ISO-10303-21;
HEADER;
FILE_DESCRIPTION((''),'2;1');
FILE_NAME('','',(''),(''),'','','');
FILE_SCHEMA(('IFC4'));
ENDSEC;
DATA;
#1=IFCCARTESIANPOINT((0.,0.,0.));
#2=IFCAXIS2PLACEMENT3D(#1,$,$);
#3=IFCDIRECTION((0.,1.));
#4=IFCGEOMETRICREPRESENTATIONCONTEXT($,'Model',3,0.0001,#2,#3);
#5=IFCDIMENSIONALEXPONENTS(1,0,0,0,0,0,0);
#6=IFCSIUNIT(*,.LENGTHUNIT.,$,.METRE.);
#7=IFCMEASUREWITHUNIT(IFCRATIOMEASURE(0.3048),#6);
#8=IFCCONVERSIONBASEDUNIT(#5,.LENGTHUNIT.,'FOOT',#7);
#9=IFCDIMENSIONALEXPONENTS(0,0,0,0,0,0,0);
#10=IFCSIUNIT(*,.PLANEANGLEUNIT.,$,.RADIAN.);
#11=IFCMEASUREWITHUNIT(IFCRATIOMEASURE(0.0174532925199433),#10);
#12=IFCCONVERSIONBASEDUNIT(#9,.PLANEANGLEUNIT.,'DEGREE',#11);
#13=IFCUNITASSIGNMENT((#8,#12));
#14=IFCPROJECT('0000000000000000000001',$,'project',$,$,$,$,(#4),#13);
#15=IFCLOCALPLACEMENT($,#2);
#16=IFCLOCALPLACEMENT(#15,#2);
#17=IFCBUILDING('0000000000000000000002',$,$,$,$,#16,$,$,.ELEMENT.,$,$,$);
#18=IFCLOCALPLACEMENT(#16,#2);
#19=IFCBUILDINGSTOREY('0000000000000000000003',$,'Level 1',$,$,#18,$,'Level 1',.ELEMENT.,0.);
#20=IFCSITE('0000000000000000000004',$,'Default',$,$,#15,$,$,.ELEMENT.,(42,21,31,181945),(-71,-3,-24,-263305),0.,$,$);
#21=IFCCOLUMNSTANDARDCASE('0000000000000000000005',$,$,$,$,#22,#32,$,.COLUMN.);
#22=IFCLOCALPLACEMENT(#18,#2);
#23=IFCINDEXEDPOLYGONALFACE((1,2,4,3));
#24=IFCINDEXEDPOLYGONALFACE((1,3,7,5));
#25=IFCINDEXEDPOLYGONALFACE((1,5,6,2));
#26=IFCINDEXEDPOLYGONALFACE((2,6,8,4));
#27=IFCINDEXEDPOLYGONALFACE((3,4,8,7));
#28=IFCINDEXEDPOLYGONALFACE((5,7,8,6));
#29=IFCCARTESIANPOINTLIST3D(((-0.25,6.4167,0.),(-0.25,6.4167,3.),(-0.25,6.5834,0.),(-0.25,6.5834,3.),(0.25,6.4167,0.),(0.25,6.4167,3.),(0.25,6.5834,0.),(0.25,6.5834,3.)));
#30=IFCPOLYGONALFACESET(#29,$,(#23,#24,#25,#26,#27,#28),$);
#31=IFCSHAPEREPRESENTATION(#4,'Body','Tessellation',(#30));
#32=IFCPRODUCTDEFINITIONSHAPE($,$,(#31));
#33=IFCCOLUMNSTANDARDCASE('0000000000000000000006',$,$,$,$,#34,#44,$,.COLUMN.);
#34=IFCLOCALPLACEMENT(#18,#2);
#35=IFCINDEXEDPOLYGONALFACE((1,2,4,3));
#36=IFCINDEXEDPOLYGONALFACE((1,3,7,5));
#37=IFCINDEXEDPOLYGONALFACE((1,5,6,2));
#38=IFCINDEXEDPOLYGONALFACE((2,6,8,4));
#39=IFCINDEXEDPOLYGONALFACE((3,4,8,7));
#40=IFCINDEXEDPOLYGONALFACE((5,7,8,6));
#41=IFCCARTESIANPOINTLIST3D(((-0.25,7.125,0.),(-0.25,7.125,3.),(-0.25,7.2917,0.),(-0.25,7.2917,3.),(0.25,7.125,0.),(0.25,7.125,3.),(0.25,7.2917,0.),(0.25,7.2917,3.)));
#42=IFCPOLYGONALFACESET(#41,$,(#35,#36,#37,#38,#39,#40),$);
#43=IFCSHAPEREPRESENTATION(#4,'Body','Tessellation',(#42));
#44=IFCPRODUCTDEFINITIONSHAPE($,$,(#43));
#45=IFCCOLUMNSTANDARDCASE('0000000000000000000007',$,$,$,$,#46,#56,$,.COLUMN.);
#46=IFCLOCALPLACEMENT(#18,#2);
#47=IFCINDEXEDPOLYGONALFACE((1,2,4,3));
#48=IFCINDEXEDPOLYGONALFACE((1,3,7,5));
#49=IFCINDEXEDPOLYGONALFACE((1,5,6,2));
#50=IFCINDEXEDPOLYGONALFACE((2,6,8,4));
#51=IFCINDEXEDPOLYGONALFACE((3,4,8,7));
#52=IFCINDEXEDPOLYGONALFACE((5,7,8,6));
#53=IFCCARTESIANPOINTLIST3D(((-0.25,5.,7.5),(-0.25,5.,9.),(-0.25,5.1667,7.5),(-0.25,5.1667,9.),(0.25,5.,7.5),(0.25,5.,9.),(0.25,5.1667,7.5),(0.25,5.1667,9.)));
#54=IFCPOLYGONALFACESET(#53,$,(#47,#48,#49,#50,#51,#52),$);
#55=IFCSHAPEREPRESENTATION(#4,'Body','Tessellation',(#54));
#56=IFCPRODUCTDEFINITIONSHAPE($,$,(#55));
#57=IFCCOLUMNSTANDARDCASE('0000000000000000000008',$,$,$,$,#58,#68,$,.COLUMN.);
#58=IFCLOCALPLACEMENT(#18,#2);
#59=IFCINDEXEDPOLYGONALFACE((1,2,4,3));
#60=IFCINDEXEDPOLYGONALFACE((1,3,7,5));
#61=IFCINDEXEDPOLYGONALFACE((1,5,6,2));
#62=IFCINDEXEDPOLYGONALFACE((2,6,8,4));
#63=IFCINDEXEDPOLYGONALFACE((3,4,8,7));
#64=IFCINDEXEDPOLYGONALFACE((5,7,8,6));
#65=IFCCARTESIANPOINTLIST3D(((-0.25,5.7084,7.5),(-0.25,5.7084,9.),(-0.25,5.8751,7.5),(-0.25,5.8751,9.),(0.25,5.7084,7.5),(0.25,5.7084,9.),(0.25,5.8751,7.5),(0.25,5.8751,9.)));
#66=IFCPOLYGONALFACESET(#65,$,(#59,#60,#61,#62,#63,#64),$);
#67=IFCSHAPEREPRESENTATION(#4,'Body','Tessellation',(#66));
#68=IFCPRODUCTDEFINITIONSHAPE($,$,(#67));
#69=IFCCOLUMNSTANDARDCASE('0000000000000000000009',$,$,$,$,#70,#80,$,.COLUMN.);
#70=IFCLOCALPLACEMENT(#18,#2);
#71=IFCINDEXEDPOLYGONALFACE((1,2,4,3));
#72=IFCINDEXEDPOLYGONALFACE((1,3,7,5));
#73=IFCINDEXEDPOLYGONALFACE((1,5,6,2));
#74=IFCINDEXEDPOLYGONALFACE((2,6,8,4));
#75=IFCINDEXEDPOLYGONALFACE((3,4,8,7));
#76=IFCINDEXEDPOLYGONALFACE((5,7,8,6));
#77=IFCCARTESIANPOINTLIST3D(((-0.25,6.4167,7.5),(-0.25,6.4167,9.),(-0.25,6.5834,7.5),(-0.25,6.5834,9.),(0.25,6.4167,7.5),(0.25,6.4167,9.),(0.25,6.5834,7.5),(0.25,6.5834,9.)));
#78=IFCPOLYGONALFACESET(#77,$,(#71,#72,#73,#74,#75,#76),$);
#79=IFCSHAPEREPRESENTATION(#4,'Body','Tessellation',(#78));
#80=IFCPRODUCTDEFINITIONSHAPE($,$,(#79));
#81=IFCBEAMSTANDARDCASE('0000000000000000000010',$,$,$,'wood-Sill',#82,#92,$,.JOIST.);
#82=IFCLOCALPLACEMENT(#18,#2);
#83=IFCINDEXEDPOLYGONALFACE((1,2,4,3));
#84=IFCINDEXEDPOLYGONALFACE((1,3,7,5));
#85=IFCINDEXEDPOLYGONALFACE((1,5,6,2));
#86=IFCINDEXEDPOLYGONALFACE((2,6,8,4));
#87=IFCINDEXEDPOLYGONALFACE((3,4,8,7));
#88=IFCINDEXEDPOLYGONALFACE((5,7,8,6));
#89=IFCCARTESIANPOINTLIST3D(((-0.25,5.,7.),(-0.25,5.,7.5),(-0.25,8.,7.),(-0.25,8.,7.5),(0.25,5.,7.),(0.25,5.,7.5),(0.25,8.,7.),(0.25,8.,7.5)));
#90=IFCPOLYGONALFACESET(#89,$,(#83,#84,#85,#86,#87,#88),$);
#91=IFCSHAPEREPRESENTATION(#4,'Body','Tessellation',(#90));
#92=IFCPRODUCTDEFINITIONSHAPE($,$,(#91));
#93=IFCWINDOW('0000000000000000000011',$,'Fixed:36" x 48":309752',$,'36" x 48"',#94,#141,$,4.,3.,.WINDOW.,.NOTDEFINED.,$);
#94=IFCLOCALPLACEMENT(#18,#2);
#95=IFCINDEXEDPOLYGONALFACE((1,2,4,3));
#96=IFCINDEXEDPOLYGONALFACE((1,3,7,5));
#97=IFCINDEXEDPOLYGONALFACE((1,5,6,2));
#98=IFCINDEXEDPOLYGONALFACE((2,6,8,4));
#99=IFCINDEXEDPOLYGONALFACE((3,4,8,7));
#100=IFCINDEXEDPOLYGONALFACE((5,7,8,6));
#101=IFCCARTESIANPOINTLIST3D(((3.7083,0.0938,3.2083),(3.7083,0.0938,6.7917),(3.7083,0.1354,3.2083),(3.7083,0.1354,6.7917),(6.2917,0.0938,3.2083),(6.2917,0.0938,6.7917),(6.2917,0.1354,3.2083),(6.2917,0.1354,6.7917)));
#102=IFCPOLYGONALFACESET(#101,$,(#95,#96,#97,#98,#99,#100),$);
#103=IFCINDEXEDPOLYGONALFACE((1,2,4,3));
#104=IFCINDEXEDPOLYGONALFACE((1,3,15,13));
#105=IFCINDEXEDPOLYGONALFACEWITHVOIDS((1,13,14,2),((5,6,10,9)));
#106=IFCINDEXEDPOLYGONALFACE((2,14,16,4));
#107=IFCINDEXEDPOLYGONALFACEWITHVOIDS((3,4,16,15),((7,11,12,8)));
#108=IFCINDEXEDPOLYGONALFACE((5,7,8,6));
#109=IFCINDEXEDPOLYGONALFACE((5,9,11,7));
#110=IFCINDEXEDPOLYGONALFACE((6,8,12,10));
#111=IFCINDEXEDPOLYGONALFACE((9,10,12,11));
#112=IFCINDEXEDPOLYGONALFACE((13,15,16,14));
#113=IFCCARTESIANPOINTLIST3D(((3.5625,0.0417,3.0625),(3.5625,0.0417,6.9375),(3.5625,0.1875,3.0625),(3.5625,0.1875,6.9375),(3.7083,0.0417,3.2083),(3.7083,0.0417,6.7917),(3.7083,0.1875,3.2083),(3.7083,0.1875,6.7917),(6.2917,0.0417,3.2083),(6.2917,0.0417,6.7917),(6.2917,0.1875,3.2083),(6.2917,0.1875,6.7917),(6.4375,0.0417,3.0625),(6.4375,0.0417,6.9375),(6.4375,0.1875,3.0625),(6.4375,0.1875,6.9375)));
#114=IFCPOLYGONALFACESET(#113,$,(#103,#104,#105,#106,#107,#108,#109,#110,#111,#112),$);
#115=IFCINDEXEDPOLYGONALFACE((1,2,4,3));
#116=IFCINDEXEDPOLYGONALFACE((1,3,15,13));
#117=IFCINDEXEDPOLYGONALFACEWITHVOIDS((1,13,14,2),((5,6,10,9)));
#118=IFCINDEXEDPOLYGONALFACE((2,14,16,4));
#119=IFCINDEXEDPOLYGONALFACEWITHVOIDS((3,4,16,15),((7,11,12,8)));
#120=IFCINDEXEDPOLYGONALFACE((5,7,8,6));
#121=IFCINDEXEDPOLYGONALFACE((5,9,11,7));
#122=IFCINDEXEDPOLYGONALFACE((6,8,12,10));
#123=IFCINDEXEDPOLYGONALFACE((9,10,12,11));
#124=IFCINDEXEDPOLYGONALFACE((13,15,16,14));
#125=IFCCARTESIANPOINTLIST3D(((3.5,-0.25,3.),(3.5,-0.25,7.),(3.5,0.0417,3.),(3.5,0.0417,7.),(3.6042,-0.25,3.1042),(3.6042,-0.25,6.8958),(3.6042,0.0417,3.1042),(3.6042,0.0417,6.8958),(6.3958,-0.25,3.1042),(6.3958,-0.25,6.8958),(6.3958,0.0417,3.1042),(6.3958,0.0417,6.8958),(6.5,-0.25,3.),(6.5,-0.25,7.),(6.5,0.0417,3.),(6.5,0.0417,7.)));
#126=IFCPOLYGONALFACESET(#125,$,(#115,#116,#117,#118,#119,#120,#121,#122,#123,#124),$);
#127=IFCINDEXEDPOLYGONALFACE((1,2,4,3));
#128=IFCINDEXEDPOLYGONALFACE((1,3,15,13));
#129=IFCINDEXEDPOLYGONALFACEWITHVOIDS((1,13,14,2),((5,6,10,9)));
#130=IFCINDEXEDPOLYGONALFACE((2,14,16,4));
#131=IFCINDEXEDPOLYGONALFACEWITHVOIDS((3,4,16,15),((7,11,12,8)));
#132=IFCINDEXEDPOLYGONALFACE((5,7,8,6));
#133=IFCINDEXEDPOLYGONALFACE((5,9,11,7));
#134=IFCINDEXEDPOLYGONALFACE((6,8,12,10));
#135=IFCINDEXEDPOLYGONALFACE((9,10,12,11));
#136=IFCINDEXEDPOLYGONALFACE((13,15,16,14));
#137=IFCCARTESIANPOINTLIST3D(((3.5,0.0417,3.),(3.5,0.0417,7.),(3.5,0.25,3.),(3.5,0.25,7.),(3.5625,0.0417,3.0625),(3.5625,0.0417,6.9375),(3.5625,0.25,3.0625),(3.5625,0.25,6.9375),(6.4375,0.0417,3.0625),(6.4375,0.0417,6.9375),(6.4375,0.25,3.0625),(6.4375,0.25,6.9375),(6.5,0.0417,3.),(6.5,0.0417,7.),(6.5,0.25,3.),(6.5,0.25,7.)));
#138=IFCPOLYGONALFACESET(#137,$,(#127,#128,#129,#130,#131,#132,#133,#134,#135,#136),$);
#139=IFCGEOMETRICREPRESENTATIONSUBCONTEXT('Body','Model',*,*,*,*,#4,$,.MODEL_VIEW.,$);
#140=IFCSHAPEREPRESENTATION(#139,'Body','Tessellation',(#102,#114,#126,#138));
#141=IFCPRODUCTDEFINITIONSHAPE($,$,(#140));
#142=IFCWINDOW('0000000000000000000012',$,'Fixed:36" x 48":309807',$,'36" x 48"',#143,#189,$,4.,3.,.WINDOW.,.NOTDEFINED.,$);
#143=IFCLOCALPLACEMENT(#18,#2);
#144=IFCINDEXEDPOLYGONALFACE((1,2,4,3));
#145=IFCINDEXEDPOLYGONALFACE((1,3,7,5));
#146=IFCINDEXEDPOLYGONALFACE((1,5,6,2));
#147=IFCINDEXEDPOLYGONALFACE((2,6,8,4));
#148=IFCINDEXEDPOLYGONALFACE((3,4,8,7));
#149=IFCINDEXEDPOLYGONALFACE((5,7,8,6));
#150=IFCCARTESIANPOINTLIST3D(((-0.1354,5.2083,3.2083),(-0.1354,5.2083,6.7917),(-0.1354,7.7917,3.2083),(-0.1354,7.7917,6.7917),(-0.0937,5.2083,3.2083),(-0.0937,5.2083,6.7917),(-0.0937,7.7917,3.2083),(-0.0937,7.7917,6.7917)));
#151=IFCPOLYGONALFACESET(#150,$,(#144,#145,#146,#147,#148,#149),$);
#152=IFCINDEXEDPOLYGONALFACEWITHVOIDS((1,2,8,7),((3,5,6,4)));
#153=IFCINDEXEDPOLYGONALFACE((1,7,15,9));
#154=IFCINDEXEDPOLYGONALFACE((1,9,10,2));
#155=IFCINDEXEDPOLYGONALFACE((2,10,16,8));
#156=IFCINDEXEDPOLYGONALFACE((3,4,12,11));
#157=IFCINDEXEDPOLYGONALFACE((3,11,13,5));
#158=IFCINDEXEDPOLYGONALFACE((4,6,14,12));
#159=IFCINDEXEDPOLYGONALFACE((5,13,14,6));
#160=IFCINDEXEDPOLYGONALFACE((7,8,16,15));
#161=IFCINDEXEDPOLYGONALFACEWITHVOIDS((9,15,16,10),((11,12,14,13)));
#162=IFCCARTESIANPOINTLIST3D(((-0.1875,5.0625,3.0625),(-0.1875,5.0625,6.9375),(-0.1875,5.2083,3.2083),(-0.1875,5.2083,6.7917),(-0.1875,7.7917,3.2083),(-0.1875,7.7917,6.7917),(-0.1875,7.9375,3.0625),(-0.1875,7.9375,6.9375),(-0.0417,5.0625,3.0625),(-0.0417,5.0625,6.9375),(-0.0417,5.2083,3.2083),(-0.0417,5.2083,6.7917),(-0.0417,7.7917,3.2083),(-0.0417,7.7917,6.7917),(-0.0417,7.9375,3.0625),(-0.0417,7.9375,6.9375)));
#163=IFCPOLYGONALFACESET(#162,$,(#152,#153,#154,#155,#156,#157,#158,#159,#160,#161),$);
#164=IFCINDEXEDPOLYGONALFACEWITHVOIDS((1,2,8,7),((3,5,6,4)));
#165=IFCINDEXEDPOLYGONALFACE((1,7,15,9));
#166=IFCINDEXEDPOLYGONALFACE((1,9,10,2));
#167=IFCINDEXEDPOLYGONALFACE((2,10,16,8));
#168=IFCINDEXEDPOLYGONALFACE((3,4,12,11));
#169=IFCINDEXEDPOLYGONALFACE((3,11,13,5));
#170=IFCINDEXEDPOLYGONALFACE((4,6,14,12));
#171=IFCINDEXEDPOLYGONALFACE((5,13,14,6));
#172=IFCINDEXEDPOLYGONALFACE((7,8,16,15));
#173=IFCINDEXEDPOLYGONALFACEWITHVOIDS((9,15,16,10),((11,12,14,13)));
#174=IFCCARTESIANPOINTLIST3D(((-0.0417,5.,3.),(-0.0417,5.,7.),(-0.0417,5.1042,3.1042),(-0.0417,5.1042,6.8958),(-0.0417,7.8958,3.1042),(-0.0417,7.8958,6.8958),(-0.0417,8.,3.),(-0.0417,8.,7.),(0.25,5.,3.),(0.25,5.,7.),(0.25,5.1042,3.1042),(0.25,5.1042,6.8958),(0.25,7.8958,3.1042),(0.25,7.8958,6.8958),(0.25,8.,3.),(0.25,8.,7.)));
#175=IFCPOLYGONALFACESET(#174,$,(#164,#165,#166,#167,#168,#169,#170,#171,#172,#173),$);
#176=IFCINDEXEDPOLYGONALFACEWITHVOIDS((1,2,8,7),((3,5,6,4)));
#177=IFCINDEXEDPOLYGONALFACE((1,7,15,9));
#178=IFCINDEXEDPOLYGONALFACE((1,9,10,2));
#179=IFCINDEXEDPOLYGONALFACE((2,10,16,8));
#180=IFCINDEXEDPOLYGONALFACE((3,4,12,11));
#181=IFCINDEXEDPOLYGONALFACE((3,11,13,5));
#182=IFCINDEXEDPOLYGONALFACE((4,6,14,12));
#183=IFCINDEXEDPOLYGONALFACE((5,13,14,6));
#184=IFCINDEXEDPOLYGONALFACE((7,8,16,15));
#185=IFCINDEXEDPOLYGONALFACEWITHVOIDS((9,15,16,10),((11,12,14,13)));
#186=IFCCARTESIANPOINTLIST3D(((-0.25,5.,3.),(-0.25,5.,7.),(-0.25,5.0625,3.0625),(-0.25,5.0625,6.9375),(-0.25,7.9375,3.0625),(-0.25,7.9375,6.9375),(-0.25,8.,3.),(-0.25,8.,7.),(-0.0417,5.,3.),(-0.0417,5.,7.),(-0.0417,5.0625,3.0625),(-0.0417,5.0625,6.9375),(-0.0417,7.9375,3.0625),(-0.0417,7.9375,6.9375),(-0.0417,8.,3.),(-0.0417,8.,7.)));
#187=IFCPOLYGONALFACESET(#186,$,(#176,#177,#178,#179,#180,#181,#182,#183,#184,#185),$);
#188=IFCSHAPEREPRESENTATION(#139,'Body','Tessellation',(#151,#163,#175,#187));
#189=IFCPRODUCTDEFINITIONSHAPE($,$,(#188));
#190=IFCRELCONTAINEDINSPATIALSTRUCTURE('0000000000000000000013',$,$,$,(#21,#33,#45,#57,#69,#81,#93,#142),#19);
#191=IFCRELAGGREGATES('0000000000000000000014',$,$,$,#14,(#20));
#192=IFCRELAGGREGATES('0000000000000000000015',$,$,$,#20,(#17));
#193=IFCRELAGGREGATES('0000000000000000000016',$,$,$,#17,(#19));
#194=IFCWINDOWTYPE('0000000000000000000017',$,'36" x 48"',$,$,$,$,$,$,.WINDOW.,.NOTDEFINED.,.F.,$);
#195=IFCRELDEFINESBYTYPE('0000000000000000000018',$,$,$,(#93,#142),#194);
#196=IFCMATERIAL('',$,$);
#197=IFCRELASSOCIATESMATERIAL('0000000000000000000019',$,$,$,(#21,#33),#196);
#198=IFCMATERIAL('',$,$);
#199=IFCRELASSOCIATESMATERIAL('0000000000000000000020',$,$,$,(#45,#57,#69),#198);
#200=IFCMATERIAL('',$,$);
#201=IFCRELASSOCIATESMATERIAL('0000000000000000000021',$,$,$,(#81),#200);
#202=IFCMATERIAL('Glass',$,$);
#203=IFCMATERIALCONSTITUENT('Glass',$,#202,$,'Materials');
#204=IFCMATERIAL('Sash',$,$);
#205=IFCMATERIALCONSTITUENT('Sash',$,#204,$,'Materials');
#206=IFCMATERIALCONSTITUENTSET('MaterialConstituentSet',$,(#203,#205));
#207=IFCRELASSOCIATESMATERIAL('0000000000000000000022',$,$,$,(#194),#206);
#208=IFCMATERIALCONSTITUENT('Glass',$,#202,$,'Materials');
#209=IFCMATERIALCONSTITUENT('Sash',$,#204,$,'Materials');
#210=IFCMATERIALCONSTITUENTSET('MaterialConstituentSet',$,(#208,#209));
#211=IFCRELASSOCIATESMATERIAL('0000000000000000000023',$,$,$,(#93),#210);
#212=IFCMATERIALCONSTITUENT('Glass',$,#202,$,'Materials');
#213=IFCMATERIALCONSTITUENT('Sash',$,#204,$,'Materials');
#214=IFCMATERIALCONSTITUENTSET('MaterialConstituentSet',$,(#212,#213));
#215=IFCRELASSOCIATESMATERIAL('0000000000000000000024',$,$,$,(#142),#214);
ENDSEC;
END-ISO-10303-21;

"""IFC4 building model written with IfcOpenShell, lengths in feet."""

from ifc_helpers import new_model, entity, si_unit, converted_unit, direction, frame, frame_2d, origin, place, context, subcontext, project, spatial, polyline, rectangle, outline, extrude, source, transform, mapped, material, constituent, constituent_set, type_object, type_shapes, element, save


model = new_model("IFC4")

# Units and contexts
model_context = context("Model", 3, precision=0.0001, world=origin(), true_north=direction((0.0, 1.0)))
body_context = subcontext(model_context, "Body", "Model", "MODEL_VIEW")
ifc_project = project(units=[converted_unit("LENGTHUNIT", "FOOT", entity("IfcRatioMeasure", 0.3048), si_unit("LENGTHUNIT", "METRE"), dimensions=[1, 0, 0, 0, 0, 0, 0]), converted_unit("PLANEANGLEUNIT", "DEGREE", entity("IfcRatioMeasure", 0.0174532925199433), si_unit("PLANEANGLEUNIT", "RADIAN"), dimensions=[0, 0, 0, 0, 0, 0, 0])], contexts=[model_context])

# Site, building, storey
site_placement = place(None, origin())
site = spatial("IfcSite", under=ifc_project, at=site_placement, Name="Default", CompositionType="ELEMENT", RefLatitude=(42, 21, 31, 181945), RefLongitude=(-71, -3, -24, -263305), RefElevation=0.0)
building_placement = place(site_placement, origin())
building = spatial("IfcBuilding", under=site, at=building_placement, CompositionType="ELEMENT")
storey_placement = place(building_placement, origin())
storey = spatial("IfcBuildingStorey", under=building, at=storey_placement, Name="Level 1", LongName="Level 1", CompositionType="ELEMENT", Elevation=0.0)

# Columns
ifc_material_1 = material(Name="")
placement_1 = place(storey_placement, frame((0.0, -0.25, 0.0), z_axis=(0.0, 0.0, 1.0), x_axis=(0.0, 1.0, 0.0)))
for number, where, z_axis, x_axis in (
    (1, (6.75, 0.0, 0.0), (0.0, 0.0, 1.0), (1.0, 0.0, 0.0)),
    (2, (7.4583, 0.0, 0.0), (0.0, 0.0, 1.0), (1.0, 0.0, 0.0)),
):
    element("IfcColumnStandardCase", number, at=place(placement_1, frame(where, z_axis=z_axis, x_axis=x_axis)), inside=storey, material=ifc_material_1, PredefinedType="COLUMN", context=model_context, shape_type="SweptSolid", body=[
        extrude(rectangle(XDim=0.1667, YDim=0.5), origin(), (0.0, 0.0, 1.0), 3.0),
    ])
ifc_material_2 = material(Name="")
for number, where, z_axis, x_axis in (
    (3, (5.3333, 0.0, 7.5), (0.0, 0.0, 1.0), (1.0, 0.0, 0.0)),
    (4, (6.0417, 0.0, 7.5), (0.0, 0.0, 1.0), (1.0, 0.0, 0.0)),
    (5, (6.75, 0.0, 7.5), (0.0, 0.0, 1.0), (1.0, 0.0, 0.0)),
):
    element("IfcColumnStandardCase", number, at=place(placement_1, frame(where, z_axis=z_axis, x_axis=x_axis)), inside=storey, material=ifc_material_2, PredefinedType="COLUMN", context=model_context, shape_type="SweptSolid", body=[
        extrude(rectangle(XDim=0.1667, YDim=0.5), origin(), (0.0, 0.0, 1.0), 1.5),
    ])
placement_2 = place(storey_placement, frame((46.25, 0.0, 0.0), z_axis=(0.0, 0.0, 1.0), x_axis=(-1.0, 0.0, 0.0)))

# Beam
ifc_material_3 = material(Name="")
for number, where, z_axis, x_axis in (
    (6, (6.75, 0.0, 7.0), (0.0, 0.0, 1.0), (1.0, 0.0, 0.0)),
):
    element("IfcBeamStandardCase", number, at=place(placement_1, frame(where, z_axis=z_axis, x_axis=x_axis)), inside=storey, material=ifc_material_3, ObjectType="wood-Sill", PredefinedType="JOIST", context=model_context, shape_type="SweptSolid", body=[
        extrude(rectangle(XDim=3.0, YDim=0.5), origin(), (0.0, 0.0, 1.0), 0.5),
    ])

# Windows
ifc_material_4 = material(Name="Glass")
ifc_constituent_1 = constituent(ifc_material_4, Name="Glass", Category="Materials")
ifc_material_5 = material(Name="Sash")
ifc_constituent_2 = constituent(ifc_material_5, Name="Sash", Category="Materials")
ifc_constituent_set_1 = constituent_set(constituents=[ifc_constituent_1, ifc_constituent_2], Name="MaterialConstituentSet")
ifc_constituent_3 = constituent(ifc_material_4, Name="Glass", Category="Materials")
ifc_constituent_4 = constituent(ifc_material_5, Name="Sash", Category="Materials")
ifc_constituent_set_2 = constituent_set(constituents=[ifc_constituent_3, ifc_constituent_4], Name="MaterialConstituentSet")
window_type = type_object("IfcWindowType", Name="36\" x 48\"", ParameterTakesPrecedence=False, PartitioningType="NOTDEFINED", PredefinedType="WINDOW", material=ifc_constituent_set_2)
shared_shape = source(origin(), body_context, "Body", "SweptSolid", [
    extrude(rectangle(XDim=0.0417, YDim=2.5833, at=frame_2d((0.0, 0.0), x_axis=(1.0, 0.0))), frame((1.5, 0.3646, 0.2083), z_axis=(0.0, 0.0, 1.0), x_axis=(0.0, 1.0, 0.0)), (0.0, 0.0, 1.0), 3.5833),
    extrude(outline(polyline([(-1.4375, -1.9375), (1.4375, -1.9375), (1.4375, 1.9375), (-1.4375, 1.9375), (-1.4375, -1.9375)]), holes=[polyline([(-1.2917, -1.7917), (-1.2917, 1.7917), (1.2917, 1.7917), (1.2917, -1.7917), (-1.2917, -1.7917)])]), frame((1.5, 0.2917, 2.0), z_axis=(0.0, 1.0, 0.0), x_axis=(1.0, 0.0, 0.0)), (0.0, 0.0, 1.0), 0.1458),
    extrude(outline(polyline([(-1.5, -2.0), (1.5, -2.0), (1.5, 2.0), (-1.5, 2.0), (-1.5, -2.0)]), holes=[polyline([(-1.3958, -1.8958), (-1.3958, 1.8958), (1.3958, 1.8958), (1.3958, -1.8958), (-1.3958, -1.8958)])]), frame((1.5, 0.0, 2.0), z_axis=(0.0, 1.0, 0.0), x_axis=(1.0, 0.0, 0.0)), (0.0, 0.0, 1.0), 0.2917),
    extrude(outline(polyline([(-2.0, -1.5), (2.0, -1.5), (2.0, 1.5), (-2.0, 1.5), (-2.0, -1.5)]), holes=[polyline([(-1.9375, -1.4375), (-1.9375, 1.4375), (1.9375, 1.4375), (1.9375, -1.4375), (-1.9375, -1.4375)])]), frame((1.5, 0.2917, 2.0), z_axis=(0.0, 1.0, 0.0), x_axis=(0.0, 0.0, -1.0)), (0.0, 0.0, 1.0), 0.2083),
])
type_shapes(window_type, [shared_shape])
placement_3 = place(placement_2, frame((42.75, 0.25, 3.0)))
window_1_placement = place(placement_3, frame((0.0, 0.0, 0.0), z_axis=(0.0, 0.0, 1.0), x_axis=(-1.0, 0.0, 0.0)))
element("IfcWindow", 7, at=window_1_placement, inside=storey, type_object=window_type, material=ifc_constituent_set_1, Name="Fixed:36\" x 48\":309752", ObjectType="36\" x 48\"", OverallHeight=4.0, OverallWidth=3.0, PartitioningType="NOTDEFINED", PredefinedType="WINDOW", context=body_context, shape_type="MappedRepresentation", body=[
    mapped(shared_shape, transform((0.0, 0.0, 0.0), scale=1.0)),
])
ifc_constituent_5 = constituent(ifc_material_4, Name="Glass", Category="Materials")
ifc_constituent_6 = constituent(ifc_material_5, Name="Sash", Category="Materials")
ifc_constituent_set_3 = constituent_set(constituents=[ifc_constituent_5, ifc_constituent_6], Name="MaterialConstituentSet")
placement_4 = place(placement_1, frame((5.25, -0.25, 3.0)))
window_2_placement = place(placement_4, origin())
element("IfcWindow", 8, at=window_2_placement, inside=storey, type_object=window_type, material=ifc_constituent_set_3, Name="Fixed:36\" x 48\":309807", ObjectType="36\" x 48\"", OverallHeight=4.0, OverallWidth=3.0, PartitioningType="NOTDEFINED", PredefinedType="WINDOW", context=body_context, shape_type="MappedRepresentation", body=[
    mapped(shared_shape, transform((0.0, 0.0, 0.0), scale=1.0)),
])

save(model, "model.ifc")
